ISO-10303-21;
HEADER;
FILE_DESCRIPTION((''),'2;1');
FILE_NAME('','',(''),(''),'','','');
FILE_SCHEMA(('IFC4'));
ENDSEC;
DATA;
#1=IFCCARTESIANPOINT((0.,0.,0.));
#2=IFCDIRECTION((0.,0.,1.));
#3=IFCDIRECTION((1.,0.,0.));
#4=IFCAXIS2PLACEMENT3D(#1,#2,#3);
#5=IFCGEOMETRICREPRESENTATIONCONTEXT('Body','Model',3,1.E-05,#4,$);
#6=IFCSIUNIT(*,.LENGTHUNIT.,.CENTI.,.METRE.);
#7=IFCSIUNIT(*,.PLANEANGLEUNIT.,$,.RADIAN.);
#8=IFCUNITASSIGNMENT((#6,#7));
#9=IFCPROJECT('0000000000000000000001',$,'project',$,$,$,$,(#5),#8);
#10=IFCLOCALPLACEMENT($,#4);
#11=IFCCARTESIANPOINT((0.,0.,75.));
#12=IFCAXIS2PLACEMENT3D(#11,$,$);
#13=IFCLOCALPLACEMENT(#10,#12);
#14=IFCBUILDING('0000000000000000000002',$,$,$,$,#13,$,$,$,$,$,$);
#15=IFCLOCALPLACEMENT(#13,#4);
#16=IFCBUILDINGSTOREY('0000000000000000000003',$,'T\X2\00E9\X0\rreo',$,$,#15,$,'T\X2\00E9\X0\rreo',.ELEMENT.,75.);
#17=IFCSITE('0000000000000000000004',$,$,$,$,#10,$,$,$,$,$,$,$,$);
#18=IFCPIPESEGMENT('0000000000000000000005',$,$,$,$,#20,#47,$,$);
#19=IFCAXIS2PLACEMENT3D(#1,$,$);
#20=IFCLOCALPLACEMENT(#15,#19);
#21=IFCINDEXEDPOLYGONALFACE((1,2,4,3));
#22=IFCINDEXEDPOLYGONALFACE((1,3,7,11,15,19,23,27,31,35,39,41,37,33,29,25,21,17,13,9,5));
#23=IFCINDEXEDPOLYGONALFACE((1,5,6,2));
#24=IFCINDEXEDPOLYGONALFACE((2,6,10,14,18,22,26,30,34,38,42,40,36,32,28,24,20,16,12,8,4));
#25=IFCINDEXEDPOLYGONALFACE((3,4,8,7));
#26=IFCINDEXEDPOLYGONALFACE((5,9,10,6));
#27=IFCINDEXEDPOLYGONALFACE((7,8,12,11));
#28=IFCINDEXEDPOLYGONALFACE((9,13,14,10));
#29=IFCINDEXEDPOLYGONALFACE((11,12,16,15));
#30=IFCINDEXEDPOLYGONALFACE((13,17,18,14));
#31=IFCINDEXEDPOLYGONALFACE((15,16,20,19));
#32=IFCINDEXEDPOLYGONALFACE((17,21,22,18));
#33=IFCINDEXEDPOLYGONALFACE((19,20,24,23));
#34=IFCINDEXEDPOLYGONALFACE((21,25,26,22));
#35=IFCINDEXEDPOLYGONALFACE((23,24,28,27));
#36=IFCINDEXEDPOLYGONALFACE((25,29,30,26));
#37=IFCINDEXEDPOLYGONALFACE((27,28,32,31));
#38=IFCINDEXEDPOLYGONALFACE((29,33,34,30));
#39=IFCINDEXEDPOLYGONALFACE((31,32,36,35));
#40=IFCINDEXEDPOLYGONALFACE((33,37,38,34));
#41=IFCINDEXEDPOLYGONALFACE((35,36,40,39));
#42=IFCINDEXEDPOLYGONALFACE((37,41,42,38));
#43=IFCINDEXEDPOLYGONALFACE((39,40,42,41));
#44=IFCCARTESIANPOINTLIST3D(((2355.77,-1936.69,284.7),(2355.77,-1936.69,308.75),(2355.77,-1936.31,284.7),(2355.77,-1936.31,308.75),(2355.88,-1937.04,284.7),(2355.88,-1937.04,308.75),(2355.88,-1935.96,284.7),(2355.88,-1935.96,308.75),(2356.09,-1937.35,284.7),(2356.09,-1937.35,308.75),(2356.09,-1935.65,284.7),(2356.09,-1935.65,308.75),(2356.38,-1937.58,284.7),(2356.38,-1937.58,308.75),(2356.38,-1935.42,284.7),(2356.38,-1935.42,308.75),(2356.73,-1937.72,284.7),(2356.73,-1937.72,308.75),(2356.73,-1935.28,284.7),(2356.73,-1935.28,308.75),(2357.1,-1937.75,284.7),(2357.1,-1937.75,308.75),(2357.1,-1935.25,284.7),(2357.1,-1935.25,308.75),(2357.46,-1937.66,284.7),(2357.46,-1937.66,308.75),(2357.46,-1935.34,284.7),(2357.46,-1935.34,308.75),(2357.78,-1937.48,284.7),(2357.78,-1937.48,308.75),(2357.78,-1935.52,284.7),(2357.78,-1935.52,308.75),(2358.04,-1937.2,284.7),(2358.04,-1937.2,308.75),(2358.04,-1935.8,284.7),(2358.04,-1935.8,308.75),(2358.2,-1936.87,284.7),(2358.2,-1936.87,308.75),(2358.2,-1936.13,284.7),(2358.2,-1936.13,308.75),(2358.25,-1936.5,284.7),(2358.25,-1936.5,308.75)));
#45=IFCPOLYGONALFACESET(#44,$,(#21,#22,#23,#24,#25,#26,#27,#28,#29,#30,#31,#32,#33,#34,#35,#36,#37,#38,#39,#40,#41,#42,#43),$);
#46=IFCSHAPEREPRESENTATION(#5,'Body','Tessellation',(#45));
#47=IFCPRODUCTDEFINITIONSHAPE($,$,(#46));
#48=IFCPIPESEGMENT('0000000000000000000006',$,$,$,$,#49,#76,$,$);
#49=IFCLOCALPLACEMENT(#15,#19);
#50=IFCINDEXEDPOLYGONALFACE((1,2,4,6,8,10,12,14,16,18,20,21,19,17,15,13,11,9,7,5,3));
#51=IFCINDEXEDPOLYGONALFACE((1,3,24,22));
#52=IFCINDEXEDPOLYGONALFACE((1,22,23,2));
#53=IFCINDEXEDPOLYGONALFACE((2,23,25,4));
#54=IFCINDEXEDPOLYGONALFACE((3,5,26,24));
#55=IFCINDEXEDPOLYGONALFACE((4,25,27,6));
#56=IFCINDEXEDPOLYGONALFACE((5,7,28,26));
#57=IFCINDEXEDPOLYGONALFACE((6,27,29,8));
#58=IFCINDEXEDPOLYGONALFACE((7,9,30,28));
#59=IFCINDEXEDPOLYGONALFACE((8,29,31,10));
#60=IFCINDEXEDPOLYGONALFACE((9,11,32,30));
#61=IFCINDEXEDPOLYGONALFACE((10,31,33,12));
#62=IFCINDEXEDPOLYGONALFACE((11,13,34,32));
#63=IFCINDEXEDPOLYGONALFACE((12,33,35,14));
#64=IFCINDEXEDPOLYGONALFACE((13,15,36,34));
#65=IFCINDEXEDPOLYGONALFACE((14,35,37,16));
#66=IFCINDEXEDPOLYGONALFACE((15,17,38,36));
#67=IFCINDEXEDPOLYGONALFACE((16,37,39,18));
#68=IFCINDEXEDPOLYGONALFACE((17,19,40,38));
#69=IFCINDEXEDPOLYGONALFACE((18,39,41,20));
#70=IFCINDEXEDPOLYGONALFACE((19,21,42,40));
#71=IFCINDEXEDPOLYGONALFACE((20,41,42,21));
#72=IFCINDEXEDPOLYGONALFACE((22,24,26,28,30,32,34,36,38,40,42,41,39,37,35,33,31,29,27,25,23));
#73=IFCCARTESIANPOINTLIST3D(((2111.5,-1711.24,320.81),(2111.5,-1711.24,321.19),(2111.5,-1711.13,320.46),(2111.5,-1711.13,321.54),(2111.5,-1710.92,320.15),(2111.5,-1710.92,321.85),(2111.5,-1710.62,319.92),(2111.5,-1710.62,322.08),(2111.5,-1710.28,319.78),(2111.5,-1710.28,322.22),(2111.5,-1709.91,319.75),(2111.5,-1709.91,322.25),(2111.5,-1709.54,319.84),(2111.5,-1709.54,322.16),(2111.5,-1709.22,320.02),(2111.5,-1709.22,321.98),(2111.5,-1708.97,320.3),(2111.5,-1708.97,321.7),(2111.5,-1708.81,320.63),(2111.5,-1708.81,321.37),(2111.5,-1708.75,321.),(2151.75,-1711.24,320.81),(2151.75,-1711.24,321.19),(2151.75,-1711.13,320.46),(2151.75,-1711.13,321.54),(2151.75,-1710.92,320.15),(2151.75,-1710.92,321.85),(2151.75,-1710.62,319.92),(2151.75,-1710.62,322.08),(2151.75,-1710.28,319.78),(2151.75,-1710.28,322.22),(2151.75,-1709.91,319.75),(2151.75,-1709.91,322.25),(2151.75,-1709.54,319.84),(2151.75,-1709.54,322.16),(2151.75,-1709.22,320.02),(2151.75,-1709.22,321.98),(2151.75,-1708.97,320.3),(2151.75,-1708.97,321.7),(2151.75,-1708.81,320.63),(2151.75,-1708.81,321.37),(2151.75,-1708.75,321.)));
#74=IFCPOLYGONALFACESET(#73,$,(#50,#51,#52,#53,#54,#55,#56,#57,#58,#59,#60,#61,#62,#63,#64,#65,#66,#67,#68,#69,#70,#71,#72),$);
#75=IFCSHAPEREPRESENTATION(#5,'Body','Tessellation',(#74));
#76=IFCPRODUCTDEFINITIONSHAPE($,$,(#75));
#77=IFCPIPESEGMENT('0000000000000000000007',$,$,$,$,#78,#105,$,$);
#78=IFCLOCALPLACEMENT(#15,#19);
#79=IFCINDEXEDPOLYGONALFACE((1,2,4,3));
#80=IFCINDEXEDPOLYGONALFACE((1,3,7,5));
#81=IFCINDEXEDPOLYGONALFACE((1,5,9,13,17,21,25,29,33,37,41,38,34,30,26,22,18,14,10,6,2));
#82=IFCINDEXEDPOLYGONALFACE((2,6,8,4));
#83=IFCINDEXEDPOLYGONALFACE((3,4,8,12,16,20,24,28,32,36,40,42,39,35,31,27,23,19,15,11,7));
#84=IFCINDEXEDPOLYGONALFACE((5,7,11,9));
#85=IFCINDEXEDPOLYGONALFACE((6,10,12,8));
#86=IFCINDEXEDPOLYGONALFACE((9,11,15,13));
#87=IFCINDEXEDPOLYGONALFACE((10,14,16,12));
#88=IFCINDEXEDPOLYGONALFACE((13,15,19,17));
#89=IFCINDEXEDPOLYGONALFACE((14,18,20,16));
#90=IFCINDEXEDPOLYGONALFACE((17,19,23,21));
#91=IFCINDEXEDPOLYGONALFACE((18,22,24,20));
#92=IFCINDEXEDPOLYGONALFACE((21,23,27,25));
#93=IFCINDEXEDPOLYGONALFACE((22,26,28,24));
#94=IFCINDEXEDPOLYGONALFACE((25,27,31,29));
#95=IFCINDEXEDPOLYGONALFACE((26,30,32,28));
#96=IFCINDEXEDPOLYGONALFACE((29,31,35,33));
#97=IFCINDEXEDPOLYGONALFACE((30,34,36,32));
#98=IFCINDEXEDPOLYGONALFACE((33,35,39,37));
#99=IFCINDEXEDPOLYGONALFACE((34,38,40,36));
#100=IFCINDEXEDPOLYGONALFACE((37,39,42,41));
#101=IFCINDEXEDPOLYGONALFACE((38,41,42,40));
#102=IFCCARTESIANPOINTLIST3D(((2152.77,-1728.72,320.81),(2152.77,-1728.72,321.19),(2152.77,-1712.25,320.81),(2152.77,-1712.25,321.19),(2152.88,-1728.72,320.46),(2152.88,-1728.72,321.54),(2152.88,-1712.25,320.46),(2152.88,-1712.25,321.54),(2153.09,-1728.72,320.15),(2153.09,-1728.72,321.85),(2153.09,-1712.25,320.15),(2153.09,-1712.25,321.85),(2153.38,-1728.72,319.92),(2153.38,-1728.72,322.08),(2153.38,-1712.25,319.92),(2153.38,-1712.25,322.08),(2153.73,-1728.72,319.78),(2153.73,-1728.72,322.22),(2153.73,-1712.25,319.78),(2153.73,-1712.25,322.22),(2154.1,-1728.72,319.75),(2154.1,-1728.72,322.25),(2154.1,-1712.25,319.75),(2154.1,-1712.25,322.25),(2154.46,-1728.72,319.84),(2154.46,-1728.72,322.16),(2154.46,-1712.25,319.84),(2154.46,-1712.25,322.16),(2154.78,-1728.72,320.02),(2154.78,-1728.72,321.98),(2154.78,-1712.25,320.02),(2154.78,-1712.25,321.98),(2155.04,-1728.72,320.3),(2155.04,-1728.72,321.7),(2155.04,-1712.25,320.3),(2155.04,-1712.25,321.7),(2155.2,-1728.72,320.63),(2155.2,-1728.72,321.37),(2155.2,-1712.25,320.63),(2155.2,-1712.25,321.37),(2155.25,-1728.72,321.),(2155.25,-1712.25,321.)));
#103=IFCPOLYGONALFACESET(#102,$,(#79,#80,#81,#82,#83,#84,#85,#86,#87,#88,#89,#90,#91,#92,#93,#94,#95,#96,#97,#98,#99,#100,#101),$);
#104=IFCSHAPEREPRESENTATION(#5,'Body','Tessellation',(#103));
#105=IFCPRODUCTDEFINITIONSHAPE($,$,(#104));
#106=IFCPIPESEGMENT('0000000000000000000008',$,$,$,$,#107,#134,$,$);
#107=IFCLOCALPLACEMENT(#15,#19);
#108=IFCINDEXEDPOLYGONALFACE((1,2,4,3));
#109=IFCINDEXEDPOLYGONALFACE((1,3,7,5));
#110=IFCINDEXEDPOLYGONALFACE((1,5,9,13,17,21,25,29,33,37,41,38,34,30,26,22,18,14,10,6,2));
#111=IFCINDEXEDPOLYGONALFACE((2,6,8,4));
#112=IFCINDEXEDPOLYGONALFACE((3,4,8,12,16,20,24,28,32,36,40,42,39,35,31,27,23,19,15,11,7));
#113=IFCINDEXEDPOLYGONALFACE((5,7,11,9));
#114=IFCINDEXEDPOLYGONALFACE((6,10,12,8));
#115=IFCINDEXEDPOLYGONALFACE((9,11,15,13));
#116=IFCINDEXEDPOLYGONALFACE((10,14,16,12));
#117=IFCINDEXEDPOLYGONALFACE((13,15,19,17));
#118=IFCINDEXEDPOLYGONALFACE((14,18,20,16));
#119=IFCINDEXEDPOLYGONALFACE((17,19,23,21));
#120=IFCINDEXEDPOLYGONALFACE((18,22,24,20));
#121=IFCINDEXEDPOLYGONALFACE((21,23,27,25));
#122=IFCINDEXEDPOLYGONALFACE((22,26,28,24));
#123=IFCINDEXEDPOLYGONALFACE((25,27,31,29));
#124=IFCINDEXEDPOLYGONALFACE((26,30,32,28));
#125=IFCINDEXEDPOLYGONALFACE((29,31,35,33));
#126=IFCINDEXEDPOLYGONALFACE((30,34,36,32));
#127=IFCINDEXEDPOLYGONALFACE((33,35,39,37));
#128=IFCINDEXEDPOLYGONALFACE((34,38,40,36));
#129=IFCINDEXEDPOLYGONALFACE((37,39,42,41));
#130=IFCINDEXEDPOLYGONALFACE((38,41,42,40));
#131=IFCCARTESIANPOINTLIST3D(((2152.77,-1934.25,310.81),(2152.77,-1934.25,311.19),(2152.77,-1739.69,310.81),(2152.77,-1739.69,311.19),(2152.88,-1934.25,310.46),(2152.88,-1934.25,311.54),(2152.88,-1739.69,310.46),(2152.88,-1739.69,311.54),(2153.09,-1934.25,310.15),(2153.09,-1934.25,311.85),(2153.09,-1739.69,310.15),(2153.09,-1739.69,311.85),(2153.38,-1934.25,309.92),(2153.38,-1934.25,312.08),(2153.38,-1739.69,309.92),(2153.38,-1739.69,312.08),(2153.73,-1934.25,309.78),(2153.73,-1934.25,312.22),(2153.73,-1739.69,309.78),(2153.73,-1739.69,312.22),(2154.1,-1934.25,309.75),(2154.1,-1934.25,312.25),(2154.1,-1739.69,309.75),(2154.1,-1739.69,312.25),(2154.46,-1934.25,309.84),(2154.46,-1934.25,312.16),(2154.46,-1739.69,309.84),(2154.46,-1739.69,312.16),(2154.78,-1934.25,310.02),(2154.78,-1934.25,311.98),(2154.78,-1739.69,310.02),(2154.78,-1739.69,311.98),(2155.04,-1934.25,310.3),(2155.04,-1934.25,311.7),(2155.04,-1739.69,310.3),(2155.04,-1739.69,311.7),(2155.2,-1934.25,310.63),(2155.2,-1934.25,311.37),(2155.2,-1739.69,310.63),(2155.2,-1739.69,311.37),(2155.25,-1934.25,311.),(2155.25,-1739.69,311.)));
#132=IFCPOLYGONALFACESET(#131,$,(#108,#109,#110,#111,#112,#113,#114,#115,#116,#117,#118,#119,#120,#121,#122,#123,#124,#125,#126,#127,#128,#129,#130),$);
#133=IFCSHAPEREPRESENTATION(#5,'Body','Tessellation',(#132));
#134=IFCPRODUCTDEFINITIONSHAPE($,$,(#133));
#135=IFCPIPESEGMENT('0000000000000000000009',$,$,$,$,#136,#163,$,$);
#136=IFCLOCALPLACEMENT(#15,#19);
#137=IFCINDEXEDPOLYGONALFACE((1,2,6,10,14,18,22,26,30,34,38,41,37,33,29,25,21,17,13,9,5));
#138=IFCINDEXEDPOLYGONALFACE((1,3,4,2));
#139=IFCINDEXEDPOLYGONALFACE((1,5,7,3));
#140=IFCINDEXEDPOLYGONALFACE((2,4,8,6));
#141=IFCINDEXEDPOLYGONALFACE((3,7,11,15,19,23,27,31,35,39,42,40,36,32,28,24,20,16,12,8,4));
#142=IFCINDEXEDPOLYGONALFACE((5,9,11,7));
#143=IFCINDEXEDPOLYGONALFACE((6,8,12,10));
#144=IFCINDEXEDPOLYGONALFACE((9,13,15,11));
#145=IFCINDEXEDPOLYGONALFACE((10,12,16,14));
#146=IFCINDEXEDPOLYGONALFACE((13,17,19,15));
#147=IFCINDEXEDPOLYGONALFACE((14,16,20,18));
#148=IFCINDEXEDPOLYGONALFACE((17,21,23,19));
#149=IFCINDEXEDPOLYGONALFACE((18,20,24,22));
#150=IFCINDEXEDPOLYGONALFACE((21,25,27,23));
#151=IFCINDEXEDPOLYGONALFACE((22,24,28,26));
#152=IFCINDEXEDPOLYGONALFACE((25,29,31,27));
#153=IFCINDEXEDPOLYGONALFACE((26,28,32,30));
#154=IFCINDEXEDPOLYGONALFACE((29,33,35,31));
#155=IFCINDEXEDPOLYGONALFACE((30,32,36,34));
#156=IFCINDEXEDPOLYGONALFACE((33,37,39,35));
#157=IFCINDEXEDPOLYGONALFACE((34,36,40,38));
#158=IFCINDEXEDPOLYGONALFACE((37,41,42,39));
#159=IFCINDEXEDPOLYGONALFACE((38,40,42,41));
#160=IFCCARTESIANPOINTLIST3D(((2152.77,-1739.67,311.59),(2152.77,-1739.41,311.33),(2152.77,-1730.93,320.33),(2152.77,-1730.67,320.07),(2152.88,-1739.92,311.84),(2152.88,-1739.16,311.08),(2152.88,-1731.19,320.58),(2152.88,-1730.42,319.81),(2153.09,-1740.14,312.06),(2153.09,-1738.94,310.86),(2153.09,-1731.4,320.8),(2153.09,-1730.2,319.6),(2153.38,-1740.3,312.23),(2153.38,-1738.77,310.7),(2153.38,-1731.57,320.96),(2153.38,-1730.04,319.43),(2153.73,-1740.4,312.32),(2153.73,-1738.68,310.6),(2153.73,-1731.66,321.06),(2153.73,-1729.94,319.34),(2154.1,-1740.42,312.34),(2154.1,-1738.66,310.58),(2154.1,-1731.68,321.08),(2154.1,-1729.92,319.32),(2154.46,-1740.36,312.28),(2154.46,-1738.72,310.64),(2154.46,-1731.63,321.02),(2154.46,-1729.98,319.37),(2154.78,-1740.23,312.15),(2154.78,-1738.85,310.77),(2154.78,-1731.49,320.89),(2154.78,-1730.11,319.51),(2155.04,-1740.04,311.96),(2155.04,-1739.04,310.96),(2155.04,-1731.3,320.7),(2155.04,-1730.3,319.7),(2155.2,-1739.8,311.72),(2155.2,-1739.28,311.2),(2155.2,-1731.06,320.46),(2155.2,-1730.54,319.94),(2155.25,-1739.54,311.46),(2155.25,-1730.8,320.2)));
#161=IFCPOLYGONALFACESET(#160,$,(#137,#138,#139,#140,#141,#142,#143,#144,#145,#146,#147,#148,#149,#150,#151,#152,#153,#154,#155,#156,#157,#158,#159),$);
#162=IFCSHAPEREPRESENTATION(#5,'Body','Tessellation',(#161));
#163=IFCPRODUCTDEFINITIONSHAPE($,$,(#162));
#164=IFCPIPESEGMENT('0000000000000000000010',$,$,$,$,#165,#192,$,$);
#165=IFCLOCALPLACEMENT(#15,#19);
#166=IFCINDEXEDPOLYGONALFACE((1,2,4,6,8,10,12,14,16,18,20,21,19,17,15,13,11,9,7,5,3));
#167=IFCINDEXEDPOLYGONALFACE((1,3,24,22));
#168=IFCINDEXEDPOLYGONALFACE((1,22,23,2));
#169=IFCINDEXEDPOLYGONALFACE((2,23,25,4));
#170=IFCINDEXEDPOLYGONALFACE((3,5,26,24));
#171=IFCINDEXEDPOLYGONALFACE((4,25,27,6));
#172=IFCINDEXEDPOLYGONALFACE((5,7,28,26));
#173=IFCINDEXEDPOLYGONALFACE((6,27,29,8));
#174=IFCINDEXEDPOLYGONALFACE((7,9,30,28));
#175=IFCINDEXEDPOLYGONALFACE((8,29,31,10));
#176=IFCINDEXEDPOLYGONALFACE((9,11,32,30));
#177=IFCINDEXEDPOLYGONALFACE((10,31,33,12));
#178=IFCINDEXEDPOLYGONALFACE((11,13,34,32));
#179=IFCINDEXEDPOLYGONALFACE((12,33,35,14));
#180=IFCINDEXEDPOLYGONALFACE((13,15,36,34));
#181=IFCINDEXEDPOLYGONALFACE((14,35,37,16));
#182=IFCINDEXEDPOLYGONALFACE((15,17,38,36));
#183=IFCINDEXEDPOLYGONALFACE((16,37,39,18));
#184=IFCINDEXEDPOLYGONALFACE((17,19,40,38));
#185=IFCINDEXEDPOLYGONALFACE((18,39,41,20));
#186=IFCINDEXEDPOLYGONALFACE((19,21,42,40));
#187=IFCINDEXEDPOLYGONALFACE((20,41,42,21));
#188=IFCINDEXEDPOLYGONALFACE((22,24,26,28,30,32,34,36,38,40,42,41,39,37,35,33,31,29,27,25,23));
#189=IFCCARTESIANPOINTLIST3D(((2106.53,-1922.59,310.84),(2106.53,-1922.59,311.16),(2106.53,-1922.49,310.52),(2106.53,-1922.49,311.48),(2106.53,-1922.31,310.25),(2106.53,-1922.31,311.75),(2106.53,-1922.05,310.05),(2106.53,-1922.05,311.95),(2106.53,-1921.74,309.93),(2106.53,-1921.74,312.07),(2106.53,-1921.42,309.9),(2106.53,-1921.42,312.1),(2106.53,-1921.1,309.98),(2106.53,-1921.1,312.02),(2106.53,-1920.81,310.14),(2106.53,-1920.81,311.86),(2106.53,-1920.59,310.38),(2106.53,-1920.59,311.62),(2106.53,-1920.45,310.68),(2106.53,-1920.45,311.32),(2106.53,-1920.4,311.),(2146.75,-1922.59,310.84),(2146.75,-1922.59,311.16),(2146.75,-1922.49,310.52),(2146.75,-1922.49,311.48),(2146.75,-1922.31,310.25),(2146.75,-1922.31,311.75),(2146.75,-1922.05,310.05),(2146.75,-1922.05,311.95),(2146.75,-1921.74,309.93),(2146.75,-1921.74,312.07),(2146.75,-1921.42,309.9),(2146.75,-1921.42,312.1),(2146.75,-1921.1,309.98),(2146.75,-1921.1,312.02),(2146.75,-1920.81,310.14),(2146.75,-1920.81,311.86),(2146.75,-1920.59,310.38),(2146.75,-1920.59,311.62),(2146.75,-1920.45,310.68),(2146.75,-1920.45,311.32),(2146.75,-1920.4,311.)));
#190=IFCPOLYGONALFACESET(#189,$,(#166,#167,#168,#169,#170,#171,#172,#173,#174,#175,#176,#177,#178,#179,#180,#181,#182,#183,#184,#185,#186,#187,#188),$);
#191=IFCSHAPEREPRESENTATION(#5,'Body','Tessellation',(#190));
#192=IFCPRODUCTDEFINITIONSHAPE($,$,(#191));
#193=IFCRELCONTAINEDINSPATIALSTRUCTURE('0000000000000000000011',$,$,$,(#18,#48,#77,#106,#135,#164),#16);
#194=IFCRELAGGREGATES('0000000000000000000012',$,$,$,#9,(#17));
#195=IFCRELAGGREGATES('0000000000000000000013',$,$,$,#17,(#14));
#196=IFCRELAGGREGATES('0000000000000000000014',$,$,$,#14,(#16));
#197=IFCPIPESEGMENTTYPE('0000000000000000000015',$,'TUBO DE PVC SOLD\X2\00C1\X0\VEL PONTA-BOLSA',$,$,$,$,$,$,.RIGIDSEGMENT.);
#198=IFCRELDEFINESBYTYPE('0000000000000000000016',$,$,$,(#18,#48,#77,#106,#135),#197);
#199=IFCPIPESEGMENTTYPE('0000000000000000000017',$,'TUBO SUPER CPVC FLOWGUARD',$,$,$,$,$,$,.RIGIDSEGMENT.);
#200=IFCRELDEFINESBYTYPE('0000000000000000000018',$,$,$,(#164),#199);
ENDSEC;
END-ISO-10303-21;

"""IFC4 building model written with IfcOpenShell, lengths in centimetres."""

from ifc_helpers import new_model, si_unit, frame, origin_with_axes, origin_2d_with_axis, place, context, project, spatial, circle, extrude, type_object, element, save


model = new_model("IFC4")

# Units and contexts
model_context = context("Model", 3, precision=1e-05, world=origin_with_axes(), identifier="Body")
ifc_project = project(units=[si_unit("LENGTHUNIT", "METRE", prefix="CENTI"), si_unit("PLANEANGLEUNIT", "RADIAN")], contexts=[model_context])

# Site, building, storey
site_placement = place(None, origin_with_axes())
site = spatial("IfcSite", under=ifc_project, at=site_placement)
building_placement = place(site_placement, frame((0.0, 0.0, 75.0)))
building = spatial("IfcBuilding", under=site, at=building_placement)
storey_placement = place(building_placement, origin_with_axes())
storey = spatial("IfcBuildingStorey", under=building, at=storey_placement, Name="Térreo", LongName="Térreo", CompositionType="ELEMENT", Elevation=75.0)

# Pipe segments
pipe_segment_type_1 = type_object("IfcPipeSegmentType", Name="TUBO DE PVC SOLDÁVEL PONTA-BOLSA", PredefinedType="RIGIDSEGMENT")
pipe_segment_1_placement = place(storey_placement, frame((2357.0, -1936.5, 308.75), z_axis=(0.0, 0.0, 1.0), x_axis=(1.0, 0.0, 0.0)))
element("IfcPipeSegment", 1, at=pipe_segment_1_placement, inside=storey, type_object=pipe_segment_type_1, context=model_context, shape_type="SolidModel", body=[
    extrude(circle(Radius=1.25, at=origin_2d_with_axis()), frame((0.0, 0.0, 0.0), z_axis=(0.0, 0.0, -1.0), x_axis=(1.0, 0.0, 0.0)), (0.0, 0.0, 1.0), 24.05),
])
pipe_segment_2_placement = place(storey_placement, frame((2131.63, -1710.0, 322.25), z_axis=(0.0, 0.0, 1.0), x_axis=(1.0, 0.0, 0.0)))
element("IfcPipeSegment", 2, at=pipe_segment_2_placement, inside=storey, type_object=pipe_segment_type_1, context=model_context, shape_type="SolidModel", body=[
    extrude(circle(Radius=1.25, at=origin_2d_with_axis()), frame((20.12, 0.0, -1.25), z_axis=(-1.0, 0.0, 0.0), x_axis=(0.0, 1.0, 0.0)), (0.0, 0.0, 1.0), 40.25),
])
pipe_segment_3_placement = place(storey_placement, frame((2154.0, -1720.49, 322.25), z_axis=(0.0, 0.0, 1.0), x_axis=(1.0, 0.0, 0.0)))
element("IfcPipeSegment", 3, at=pipe_segment_3_placement, inside=storey, type_object=pipe_segment_type_1, context=model_context, shape_type="SolidModel", body=[
    extrude(circle(Radius=1.25, at=origin_2d_with_axis()), frame((0.0, 8.24, -1.25), z_axis=(0.0, -1.0, 0.0), x_axis=(1.0, 0.0, 0.0)), (0.0, 0.0, 1.0), 16.47),
])
pipe_segment_4_placement = place(storey_placement, frame((2154.0, -1836.97, 312.25), z_axis=(0.0, 0.0, 1.0), x_axis=(1.0, 0.0, 0.0)))
element("IfcPipeSegment", 4, at=pipe_segment_4_placement, inside=storey, type_object=pipe_segment_type_1, context=model_context, shape_type="SolidModel", body=[
    extrude(circle(Radius=1.25, at=origin_2d_with_axis()), frame((0.0, 97.28, -1.25), z_axis=(0.0, -1.0, 0.0), x_axis=(1.0, 0.0, 0.0)), (0.0, 0.0, 1.0), 194.56),
])
pipe_segment_5_placement = place(storey_placement, frame((2154.0, -1735.17, 321.08), z_axis=(0.0, 0.0, 1.0), x_axis=(1.0, 0.0, 0.0)))
element("IfcPipeSegment", 5, at=pipe_segment_5_placement, inside=storey, type_object=pipe_segment_type_1, context=model_context, shape_type="SolidModel", body=[
    extrude(circle(Radius=1.25, at=origin_2d_with_axis()), frame((0.0, 4.37, -0.88), z_axis=(0.0, -0.707107, -0.707107), x_axis=(1.0, 0.0, 0.0)), (0.0, 0.0, 1.0), 12.36),
])
pipe_segment_type_2 = type_object("IfcPipeSegmentType", Name="TUBO SUPER CPVC FLOWGUARD", PredefinedType="RIGIDSEGMENT")
pipe_segment_6_placement = place(storey_placement, frame((2126.64, -1921.5, 312.1), z_axis=(0.0, 0.0, 1.0), x_axis=(1.0, 0.0, 0.0)))
element("IfcPipeSegment", 6, at=pipe_segment_6_placement, inside=storey, type_object=pipe_segment_type_2, context=model_context, shape_type="SolidModel", body=[
    extrude(circle(Radius=1.1, at=origin_2d_with_axis()), frame((-20.11, 0.0, -1.1), z_axis=(1.0, 0.0, 0.0), x_axis=(0.0, 1.0, 0.0)), (0.0, 0.0, 1.0), 40.22),
])

save(model, "model.ifc")
